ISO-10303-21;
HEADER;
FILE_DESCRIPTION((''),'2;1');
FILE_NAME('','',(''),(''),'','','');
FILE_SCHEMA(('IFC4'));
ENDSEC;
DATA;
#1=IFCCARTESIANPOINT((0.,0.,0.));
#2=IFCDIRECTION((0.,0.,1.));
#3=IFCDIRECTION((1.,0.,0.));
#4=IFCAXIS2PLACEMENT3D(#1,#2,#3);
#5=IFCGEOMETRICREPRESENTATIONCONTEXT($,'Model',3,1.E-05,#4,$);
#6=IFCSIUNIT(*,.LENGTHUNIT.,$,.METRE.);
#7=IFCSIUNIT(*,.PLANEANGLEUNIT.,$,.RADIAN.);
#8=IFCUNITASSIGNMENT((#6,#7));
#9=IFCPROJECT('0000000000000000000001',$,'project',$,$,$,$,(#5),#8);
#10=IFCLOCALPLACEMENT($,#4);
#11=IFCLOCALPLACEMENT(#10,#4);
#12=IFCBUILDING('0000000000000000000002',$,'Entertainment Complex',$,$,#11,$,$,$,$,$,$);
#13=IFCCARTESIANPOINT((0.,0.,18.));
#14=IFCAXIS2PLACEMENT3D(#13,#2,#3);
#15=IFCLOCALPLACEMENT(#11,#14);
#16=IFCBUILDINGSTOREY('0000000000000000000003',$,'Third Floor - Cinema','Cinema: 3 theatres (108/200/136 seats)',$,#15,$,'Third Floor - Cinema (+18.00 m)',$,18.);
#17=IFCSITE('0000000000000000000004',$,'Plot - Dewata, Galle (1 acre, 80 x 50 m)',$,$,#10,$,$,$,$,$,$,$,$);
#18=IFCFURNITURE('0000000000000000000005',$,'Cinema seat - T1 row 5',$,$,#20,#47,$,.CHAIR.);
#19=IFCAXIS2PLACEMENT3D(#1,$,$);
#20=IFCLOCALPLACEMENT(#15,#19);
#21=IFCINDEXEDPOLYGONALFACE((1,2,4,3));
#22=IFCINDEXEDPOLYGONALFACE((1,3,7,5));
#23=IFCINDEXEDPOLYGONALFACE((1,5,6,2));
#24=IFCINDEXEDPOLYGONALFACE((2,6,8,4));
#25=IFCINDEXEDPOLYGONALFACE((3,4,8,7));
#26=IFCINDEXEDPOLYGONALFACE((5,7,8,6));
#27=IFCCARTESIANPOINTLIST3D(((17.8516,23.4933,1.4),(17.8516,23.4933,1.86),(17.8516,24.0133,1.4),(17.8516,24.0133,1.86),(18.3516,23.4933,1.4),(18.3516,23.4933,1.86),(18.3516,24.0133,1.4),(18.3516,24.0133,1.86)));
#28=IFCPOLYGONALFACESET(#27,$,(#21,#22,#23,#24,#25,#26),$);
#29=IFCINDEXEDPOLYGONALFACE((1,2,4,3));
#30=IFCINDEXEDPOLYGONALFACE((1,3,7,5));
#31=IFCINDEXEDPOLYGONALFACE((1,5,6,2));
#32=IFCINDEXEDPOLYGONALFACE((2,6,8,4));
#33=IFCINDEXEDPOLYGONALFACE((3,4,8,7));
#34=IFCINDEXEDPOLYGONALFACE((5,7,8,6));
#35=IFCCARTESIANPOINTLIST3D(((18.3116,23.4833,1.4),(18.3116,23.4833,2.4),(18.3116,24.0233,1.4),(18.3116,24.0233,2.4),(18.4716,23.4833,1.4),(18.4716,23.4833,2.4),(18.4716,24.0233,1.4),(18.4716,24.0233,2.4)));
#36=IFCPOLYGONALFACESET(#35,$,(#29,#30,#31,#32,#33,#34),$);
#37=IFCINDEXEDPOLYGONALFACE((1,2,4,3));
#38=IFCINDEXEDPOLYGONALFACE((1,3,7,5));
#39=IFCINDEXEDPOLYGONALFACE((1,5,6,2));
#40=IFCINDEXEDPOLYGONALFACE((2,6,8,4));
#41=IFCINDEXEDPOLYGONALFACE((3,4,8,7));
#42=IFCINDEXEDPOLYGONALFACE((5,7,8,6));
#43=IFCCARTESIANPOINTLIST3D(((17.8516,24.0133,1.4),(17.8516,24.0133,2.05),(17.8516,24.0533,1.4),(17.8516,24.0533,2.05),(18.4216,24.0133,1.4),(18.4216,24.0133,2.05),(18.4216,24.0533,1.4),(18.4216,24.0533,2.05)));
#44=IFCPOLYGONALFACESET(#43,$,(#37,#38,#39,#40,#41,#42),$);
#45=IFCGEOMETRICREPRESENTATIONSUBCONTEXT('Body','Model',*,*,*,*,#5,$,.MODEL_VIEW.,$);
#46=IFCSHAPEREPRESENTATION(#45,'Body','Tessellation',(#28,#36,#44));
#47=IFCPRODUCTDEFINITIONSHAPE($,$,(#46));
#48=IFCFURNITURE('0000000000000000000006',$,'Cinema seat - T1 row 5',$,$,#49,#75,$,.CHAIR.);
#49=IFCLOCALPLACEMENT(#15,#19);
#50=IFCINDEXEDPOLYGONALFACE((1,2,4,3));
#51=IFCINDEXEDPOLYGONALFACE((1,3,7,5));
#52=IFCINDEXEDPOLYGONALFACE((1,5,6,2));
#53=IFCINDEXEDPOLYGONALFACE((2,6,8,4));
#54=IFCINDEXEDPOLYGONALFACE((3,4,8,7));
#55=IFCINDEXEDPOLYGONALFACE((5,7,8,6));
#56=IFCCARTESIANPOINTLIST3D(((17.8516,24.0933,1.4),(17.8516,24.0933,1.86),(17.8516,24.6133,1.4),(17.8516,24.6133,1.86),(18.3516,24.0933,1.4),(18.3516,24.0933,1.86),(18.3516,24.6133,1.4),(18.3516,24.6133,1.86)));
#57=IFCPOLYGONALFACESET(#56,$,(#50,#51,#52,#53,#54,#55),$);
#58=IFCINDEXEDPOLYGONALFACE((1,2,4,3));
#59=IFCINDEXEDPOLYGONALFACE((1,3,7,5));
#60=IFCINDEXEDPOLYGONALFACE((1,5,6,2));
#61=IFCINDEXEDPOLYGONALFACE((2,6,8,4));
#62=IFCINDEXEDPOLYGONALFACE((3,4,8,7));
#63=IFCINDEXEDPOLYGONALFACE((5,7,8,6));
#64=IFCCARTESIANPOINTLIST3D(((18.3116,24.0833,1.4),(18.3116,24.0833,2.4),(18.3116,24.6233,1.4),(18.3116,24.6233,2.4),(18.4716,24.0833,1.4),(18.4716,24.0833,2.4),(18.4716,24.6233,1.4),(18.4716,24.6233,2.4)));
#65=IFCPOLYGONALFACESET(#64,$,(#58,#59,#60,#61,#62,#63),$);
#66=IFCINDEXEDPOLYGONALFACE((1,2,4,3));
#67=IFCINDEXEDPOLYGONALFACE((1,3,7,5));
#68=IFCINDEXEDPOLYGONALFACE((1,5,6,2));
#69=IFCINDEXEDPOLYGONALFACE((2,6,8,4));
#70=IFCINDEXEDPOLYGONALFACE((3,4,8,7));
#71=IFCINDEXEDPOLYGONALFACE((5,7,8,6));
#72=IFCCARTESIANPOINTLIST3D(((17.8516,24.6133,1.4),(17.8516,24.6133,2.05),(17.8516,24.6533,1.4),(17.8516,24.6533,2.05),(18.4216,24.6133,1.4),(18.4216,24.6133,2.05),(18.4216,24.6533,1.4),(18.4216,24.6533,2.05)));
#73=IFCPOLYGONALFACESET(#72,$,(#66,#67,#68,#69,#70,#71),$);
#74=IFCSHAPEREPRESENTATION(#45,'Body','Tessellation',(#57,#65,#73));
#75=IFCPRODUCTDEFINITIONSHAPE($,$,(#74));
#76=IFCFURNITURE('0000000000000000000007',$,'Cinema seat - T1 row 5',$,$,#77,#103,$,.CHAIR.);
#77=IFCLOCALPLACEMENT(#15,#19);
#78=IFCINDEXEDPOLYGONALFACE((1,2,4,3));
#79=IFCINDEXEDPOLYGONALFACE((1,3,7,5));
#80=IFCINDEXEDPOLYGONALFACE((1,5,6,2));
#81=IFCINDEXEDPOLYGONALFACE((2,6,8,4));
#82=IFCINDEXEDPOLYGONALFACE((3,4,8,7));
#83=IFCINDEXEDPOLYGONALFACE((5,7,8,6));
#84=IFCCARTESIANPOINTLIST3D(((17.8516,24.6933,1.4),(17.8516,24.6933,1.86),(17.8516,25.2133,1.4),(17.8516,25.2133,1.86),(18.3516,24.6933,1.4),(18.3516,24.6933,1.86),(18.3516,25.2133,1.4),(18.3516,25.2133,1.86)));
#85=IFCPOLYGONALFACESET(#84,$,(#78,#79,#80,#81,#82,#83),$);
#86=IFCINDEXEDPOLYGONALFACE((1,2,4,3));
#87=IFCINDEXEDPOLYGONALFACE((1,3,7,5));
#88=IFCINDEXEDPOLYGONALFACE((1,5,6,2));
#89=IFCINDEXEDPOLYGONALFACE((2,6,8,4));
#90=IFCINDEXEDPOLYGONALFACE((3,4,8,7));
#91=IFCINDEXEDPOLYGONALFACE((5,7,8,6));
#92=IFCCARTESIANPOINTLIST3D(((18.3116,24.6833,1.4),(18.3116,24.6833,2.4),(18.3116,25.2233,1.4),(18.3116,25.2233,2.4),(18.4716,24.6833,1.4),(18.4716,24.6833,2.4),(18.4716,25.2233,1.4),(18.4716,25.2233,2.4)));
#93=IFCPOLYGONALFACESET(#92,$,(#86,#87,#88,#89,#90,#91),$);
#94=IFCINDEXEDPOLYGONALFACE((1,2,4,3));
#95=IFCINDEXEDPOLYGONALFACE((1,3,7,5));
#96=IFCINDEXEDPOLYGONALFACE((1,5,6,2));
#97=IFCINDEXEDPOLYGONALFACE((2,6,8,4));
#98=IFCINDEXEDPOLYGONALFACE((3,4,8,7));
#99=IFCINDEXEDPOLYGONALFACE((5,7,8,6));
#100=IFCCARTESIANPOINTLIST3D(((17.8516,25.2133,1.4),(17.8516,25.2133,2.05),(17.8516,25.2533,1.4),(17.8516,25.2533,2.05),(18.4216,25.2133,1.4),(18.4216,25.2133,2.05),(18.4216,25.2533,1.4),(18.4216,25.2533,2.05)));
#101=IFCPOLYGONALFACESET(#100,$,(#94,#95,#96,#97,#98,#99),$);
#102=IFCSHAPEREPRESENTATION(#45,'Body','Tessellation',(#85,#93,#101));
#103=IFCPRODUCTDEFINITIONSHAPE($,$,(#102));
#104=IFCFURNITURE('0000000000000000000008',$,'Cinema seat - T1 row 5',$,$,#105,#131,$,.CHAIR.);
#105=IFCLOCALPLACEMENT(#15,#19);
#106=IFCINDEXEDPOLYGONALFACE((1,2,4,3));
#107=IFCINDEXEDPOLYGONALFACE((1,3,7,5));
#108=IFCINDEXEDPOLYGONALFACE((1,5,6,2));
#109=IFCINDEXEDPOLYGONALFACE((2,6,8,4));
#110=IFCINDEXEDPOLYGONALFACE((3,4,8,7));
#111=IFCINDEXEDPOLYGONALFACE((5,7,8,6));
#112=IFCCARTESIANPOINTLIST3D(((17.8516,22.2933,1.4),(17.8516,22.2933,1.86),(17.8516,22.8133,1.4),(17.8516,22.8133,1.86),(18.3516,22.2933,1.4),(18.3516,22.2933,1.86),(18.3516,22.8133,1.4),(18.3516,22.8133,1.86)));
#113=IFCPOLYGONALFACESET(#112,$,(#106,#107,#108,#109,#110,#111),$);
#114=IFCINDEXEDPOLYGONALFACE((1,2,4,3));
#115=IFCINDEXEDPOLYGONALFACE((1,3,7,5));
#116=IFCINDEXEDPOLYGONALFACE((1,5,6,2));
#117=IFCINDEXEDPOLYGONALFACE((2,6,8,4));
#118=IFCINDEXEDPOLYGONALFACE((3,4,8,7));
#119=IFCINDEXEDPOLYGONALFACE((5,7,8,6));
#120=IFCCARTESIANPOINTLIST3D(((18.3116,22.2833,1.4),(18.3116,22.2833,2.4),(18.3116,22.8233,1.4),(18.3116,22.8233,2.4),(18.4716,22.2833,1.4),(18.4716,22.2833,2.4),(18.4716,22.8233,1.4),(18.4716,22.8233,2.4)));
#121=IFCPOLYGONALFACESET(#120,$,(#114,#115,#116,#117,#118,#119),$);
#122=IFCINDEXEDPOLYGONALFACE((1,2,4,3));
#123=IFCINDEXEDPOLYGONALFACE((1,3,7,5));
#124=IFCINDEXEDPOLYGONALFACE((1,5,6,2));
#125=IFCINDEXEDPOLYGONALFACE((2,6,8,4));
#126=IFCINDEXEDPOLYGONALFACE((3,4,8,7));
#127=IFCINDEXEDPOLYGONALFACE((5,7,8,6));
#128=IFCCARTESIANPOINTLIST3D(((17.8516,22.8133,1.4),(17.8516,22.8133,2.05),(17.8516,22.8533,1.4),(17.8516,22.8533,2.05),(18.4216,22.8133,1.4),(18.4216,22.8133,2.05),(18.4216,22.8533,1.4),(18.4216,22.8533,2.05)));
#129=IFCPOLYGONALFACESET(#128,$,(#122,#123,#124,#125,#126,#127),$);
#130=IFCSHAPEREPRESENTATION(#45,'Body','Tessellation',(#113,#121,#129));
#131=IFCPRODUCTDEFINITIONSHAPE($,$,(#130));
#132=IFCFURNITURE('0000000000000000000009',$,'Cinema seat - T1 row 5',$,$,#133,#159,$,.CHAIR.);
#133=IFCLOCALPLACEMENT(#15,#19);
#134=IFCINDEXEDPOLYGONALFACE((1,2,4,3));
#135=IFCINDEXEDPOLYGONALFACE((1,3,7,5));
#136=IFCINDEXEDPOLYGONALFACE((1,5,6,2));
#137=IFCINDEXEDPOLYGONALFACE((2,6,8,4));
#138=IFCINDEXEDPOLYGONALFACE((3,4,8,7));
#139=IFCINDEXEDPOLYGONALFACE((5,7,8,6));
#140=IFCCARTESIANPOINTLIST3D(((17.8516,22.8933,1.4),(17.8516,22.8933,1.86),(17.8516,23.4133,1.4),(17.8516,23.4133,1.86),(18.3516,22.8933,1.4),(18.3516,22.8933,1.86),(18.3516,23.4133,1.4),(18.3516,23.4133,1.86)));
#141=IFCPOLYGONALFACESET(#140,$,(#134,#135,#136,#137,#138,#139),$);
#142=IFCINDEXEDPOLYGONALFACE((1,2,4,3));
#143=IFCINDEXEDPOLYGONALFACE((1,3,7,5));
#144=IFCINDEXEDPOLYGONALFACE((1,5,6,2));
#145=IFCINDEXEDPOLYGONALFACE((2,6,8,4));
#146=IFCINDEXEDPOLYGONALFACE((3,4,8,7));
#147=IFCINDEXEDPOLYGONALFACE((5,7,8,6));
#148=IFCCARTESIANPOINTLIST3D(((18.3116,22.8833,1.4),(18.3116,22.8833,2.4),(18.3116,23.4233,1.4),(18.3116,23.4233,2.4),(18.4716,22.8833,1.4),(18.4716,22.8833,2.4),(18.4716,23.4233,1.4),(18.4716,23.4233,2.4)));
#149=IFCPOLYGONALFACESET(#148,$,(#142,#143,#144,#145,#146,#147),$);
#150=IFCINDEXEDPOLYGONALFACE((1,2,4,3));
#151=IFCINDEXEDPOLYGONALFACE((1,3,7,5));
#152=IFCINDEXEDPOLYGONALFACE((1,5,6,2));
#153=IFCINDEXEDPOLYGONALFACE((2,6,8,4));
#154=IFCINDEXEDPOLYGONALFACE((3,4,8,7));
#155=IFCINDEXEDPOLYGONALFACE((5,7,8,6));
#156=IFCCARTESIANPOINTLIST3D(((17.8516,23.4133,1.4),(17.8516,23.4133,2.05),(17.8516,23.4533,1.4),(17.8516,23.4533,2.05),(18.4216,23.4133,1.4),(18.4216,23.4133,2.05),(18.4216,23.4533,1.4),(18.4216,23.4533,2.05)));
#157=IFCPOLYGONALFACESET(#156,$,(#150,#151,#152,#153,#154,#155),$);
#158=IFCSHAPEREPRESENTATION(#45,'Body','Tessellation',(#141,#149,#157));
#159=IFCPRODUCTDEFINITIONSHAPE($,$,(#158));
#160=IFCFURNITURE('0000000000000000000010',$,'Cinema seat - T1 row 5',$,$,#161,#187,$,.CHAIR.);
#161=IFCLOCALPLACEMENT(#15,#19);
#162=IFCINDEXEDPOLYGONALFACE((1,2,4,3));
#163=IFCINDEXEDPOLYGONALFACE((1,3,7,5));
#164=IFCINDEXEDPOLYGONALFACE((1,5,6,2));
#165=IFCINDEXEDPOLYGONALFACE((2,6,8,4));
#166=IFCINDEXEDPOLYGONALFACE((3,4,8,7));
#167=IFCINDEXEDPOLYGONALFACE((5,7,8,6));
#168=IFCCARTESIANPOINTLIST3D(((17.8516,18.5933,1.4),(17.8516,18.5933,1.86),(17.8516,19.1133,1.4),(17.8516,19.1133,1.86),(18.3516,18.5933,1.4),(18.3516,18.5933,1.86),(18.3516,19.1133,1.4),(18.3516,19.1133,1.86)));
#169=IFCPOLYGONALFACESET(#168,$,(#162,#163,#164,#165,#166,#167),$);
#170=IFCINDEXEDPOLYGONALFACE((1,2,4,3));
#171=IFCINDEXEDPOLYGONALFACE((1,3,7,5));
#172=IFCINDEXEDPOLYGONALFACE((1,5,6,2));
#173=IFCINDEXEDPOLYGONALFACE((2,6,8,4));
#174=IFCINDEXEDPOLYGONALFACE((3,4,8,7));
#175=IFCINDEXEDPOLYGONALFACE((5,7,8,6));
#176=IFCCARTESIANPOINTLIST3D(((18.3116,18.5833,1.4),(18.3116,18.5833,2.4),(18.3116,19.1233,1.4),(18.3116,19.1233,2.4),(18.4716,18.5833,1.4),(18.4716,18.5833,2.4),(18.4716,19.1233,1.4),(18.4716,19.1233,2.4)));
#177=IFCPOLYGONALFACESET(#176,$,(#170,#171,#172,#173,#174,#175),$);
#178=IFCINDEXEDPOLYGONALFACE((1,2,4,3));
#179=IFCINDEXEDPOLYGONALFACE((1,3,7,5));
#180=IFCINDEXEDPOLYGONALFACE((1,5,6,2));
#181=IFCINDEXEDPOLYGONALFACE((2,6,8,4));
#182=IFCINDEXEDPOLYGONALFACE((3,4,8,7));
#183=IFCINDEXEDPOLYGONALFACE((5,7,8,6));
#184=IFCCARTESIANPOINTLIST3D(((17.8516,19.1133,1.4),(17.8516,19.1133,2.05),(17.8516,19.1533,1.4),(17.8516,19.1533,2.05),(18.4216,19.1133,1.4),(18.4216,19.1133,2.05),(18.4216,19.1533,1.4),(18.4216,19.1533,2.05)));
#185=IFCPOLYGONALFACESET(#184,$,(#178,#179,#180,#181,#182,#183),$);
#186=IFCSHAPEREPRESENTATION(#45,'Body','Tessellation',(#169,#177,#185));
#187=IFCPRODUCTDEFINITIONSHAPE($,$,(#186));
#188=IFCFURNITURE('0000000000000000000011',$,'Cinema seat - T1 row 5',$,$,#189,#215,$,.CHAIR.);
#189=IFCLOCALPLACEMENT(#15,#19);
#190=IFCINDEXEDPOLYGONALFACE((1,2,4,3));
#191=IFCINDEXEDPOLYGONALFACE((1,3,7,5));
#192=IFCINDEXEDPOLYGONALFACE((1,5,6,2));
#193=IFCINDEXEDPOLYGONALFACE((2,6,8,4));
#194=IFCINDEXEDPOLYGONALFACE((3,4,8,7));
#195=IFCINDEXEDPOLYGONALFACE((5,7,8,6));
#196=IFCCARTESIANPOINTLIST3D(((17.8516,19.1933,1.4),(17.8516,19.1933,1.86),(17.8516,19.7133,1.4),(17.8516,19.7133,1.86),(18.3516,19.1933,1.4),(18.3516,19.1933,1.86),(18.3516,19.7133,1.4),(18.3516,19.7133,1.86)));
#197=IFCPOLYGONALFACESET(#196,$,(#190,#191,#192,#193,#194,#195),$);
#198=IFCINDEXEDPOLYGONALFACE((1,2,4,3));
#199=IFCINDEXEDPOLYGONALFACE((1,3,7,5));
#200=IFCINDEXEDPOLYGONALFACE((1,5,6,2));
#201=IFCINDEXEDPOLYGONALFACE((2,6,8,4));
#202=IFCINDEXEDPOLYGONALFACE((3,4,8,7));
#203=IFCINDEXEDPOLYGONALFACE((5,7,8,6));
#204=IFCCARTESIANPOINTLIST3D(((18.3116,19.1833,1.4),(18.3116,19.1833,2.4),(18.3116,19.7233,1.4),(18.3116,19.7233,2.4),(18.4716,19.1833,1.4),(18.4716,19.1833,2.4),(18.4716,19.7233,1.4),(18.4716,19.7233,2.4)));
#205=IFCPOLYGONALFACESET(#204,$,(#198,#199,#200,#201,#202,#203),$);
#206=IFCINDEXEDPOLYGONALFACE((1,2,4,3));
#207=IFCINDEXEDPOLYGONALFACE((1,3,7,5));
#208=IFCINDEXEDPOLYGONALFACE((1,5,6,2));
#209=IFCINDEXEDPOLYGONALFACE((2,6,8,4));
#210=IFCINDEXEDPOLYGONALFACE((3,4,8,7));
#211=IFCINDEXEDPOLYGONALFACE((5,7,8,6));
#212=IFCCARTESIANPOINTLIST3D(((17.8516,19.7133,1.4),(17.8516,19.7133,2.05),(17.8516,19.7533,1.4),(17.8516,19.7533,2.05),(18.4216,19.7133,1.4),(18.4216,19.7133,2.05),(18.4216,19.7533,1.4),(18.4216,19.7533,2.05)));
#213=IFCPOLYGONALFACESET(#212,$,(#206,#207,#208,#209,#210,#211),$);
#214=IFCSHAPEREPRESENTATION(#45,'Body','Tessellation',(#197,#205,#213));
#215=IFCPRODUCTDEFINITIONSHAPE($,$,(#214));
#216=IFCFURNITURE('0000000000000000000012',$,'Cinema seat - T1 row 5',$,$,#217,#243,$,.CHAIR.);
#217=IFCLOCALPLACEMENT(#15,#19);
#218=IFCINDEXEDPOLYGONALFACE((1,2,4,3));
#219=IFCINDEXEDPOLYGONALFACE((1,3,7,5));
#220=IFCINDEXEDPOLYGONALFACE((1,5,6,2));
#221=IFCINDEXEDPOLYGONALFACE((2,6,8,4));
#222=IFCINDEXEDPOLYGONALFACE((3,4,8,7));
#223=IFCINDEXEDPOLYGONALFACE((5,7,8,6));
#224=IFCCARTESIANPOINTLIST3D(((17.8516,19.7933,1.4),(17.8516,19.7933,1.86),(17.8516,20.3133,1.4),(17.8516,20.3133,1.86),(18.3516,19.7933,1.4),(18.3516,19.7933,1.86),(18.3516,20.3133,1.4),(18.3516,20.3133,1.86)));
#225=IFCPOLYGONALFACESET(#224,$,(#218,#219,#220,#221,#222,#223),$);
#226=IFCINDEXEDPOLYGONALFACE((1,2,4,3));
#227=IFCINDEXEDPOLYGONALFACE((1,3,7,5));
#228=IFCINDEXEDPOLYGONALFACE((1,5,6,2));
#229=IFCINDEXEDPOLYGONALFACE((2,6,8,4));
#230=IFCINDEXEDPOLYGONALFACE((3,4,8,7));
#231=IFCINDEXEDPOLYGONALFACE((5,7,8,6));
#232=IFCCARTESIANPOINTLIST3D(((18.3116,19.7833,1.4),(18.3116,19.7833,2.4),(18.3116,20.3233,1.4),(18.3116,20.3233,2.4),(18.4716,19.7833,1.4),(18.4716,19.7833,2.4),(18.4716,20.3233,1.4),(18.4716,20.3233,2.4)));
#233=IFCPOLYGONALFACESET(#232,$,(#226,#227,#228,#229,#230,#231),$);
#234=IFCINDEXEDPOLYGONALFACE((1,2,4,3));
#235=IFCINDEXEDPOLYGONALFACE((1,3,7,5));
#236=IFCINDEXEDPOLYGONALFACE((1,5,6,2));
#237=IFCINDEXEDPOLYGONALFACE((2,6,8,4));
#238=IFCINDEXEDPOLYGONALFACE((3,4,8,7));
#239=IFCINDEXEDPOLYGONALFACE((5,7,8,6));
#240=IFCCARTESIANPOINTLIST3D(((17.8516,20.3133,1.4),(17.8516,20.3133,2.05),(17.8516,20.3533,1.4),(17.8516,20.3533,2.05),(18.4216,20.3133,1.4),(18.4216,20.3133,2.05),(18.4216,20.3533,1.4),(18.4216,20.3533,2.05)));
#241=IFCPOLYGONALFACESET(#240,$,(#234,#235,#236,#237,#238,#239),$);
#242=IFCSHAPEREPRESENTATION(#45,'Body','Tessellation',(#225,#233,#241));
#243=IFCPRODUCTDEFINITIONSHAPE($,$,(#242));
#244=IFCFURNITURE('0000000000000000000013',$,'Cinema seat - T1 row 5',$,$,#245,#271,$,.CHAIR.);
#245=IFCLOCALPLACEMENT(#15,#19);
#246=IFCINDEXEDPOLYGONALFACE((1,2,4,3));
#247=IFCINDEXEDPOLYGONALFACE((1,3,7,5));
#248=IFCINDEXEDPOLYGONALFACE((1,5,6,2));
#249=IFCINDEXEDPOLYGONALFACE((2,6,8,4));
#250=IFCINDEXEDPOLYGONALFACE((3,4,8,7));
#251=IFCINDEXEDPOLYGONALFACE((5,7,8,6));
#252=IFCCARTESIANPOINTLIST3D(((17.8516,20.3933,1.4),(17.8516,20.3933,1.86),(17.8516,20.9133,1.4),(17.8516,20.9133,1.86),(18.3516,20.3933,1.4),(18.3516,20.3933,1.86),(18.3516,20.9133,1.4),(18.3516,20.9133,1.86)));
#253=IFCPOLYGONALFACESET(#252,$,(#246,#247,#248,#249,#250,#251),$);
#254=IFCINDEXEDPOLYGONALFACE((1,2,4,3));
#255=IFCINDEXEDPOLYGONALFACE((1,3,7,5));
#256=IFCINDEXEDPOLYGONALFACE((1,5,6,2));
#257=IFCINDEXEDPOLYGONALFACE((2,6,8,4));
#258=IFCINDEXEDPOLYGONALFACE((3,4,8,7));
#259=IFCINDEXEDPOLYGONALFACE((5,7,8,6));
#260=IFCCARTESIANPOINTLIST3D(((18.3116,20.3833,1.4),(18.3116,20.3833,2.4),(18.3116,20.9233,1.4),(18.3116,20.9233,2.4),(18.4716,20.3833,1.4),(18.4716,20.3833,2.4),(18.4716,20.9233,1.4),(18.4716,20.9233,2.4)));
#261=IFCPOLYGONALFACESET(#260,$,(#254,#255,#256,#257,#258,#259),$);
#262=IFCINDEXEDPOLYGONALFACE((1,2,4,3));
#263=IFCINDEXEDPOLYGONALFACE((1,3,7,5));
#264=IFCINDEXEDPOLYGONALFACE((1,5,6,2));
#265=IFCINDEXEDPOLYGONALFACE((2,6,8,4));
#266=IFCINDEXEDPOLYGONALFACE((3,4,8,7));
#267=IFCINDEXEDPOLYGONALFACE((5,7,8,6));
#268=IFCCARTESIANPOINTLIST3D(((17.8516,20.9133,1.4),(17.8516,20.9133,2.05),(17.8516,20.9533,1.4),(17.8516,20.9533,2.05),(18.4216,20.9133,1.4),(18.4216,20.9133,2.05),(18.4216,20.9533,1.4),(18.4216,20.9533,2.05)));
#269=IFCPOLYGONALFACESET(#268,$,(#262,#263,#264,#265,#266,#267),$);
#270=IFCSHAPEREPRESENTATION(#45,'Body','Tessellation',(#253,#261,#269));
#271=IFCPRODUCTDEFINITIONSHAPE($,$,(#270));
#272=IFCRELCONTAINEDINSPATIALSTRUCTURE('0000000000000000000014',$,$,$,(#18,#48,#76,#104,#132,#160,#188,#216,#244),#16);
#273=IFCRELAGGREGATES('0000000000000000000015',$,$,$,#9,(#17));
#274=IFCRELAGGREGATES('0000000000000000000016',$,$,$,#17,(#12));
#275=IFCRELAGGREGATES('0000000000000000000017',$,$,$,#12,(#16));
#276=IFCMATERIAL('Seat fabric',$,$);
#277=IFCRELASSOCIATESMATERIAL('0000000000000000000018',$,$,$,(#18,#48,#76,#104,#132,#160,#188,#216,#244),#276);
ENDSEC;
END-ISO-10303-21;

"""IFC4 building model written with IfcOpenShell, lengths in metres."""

from ifc_helpers import new_model, si_unit, frame, origin_with_axes, place, context, subcontext, project, spatial, polyline, outline, extrude, material, element, save


model = new_model("IFC4")

# Units and contexts
model_context = context("Model", 3, precision=1e-05, world=origin_with_axes())
body_context = subcontext(model_context, "Body", "Model", "MODEL_VIEW")
ifc_project = project(units=[si_unit("LENGTHUNIT", "METRE"), si_unit("PLANEANGLEUNIT", "RADIAN")], contexts=[model_context])

# Site, building, storey
site_placement = place(None, origin_with_axes())
site = spatial("IfcSite", under=ifc_project, at=site_placement, Name="Plot - Dewata, Galle (1 acre, 80 x 50 m)")
building_placement = place(site_placement, origin_with_axes())
building = spatial("IfcBuilding", under=site, at=building_placement, Name="Entertainment Complex")
storey_placement = place(building_placement, frame((0.0, 0.0, 18.0), z_axis=(0.0, 0.0, 1.0), x_axis=(1.0, 0.0, 0.0)))
storey = spatial("IfcBuildingStorey", under=building, at=storey_placement, Name="Third Floor - Cinema", Description="Cinema: 3 theatres (108/200/136 seats)", LongName="Third Floor - Cinema (+18.00 m)", Elevation=18.0)

# Furniture
ifc_material = material(Name="Seat fabric")
for number, where, z_axis, x_axis, name in (
    (1, (18.4716, 23.7533, 1.4), (0.0, 0.0, 1.0), (1.0, 0.0, 0.0), "Cinema seat - T1 row 5"),
    (2, (18.4716, 24.3533, 1.4), (0.0, 0.0, 1.0), (1.0, 0.0, 0.0), "Cinema seat - T1 row 5"),
    (3, (18.4716, 24.9533, 1.4), (0.0, 0.0, 1.0), (1.0, 0.0, 0.0), "Cinema seat - T1 row 5"),
    (4, (18.4716, 22.5533, 1.4), (0.0, 0.0, 1.0), (1.0, 0.0, 0.0), "Cinema seat - T1 row 5"),
    (5, (18.4716, 23.1533, 1.4), (0.0, 0.0, 1.0), (1.0, 0.0, 0.0), "Cinema seat - T1 row 5"),
    (6, (18.4716, 18.8533, 1.4), (0.0, 0.0, 1.0), (1.0, 0.0, 0.0), "Cinema seat - T1 row 5"),
    (7, (18.4716, 19.4533, 1.4), (0.0, 0.0, 1.0), (1.0, 0.0, 0.0), "Cinema seat - T1 row 5"),
    (8, (18.4716, 20.0533, 1.4), (0.0, 0.0, 1.0), (1.0, 0.0, 0.0), "Cinema seat - T1 row 5"),
    (9, (18.4716, 20.6533, 1.4), (0.0, 0.0, 1.0), (1.0, 0.0, 0.0), "Cinema seat - T1 row 5"),
):
    element("IfcFurniture", number, at=place(storey_placement, frame(where, z_axis=z_axis, x_axis=x_axis)), inside=storey, material=ifc_material, Name=name, PredefinedType="CHAIR", context=body_context, shape_type="SweptSolid", body=[
        extrude(outline(polyline([(-0.62, -0.26), (-0.12, -0.26), (-0.12, 0.26), (-0.62, 0.26), (-0.62, -0.26)])), origin_with_axes(), (0.0, 0.0, 1.0), 0.46),
        extrude(outline(polyline([(-0.16, -0.27), (0.0, -0.27), (0.0, 0.27), (-0.16, 0.27), (-0.16, -0.27)])), origin_with_axes(), (0.0, 0.0, 1.0), 1.0),
        extrude(outline(polyline([(-0.62, 0.26), (-0.05, 0.26), (-0.05, 0.3), (-0.62, 0.3), (-0.62, 0.26)])), origin_with_axes(), (0.0, 0.0, 1.0), 0.65),
    ])

save(model, "model.ifc")
